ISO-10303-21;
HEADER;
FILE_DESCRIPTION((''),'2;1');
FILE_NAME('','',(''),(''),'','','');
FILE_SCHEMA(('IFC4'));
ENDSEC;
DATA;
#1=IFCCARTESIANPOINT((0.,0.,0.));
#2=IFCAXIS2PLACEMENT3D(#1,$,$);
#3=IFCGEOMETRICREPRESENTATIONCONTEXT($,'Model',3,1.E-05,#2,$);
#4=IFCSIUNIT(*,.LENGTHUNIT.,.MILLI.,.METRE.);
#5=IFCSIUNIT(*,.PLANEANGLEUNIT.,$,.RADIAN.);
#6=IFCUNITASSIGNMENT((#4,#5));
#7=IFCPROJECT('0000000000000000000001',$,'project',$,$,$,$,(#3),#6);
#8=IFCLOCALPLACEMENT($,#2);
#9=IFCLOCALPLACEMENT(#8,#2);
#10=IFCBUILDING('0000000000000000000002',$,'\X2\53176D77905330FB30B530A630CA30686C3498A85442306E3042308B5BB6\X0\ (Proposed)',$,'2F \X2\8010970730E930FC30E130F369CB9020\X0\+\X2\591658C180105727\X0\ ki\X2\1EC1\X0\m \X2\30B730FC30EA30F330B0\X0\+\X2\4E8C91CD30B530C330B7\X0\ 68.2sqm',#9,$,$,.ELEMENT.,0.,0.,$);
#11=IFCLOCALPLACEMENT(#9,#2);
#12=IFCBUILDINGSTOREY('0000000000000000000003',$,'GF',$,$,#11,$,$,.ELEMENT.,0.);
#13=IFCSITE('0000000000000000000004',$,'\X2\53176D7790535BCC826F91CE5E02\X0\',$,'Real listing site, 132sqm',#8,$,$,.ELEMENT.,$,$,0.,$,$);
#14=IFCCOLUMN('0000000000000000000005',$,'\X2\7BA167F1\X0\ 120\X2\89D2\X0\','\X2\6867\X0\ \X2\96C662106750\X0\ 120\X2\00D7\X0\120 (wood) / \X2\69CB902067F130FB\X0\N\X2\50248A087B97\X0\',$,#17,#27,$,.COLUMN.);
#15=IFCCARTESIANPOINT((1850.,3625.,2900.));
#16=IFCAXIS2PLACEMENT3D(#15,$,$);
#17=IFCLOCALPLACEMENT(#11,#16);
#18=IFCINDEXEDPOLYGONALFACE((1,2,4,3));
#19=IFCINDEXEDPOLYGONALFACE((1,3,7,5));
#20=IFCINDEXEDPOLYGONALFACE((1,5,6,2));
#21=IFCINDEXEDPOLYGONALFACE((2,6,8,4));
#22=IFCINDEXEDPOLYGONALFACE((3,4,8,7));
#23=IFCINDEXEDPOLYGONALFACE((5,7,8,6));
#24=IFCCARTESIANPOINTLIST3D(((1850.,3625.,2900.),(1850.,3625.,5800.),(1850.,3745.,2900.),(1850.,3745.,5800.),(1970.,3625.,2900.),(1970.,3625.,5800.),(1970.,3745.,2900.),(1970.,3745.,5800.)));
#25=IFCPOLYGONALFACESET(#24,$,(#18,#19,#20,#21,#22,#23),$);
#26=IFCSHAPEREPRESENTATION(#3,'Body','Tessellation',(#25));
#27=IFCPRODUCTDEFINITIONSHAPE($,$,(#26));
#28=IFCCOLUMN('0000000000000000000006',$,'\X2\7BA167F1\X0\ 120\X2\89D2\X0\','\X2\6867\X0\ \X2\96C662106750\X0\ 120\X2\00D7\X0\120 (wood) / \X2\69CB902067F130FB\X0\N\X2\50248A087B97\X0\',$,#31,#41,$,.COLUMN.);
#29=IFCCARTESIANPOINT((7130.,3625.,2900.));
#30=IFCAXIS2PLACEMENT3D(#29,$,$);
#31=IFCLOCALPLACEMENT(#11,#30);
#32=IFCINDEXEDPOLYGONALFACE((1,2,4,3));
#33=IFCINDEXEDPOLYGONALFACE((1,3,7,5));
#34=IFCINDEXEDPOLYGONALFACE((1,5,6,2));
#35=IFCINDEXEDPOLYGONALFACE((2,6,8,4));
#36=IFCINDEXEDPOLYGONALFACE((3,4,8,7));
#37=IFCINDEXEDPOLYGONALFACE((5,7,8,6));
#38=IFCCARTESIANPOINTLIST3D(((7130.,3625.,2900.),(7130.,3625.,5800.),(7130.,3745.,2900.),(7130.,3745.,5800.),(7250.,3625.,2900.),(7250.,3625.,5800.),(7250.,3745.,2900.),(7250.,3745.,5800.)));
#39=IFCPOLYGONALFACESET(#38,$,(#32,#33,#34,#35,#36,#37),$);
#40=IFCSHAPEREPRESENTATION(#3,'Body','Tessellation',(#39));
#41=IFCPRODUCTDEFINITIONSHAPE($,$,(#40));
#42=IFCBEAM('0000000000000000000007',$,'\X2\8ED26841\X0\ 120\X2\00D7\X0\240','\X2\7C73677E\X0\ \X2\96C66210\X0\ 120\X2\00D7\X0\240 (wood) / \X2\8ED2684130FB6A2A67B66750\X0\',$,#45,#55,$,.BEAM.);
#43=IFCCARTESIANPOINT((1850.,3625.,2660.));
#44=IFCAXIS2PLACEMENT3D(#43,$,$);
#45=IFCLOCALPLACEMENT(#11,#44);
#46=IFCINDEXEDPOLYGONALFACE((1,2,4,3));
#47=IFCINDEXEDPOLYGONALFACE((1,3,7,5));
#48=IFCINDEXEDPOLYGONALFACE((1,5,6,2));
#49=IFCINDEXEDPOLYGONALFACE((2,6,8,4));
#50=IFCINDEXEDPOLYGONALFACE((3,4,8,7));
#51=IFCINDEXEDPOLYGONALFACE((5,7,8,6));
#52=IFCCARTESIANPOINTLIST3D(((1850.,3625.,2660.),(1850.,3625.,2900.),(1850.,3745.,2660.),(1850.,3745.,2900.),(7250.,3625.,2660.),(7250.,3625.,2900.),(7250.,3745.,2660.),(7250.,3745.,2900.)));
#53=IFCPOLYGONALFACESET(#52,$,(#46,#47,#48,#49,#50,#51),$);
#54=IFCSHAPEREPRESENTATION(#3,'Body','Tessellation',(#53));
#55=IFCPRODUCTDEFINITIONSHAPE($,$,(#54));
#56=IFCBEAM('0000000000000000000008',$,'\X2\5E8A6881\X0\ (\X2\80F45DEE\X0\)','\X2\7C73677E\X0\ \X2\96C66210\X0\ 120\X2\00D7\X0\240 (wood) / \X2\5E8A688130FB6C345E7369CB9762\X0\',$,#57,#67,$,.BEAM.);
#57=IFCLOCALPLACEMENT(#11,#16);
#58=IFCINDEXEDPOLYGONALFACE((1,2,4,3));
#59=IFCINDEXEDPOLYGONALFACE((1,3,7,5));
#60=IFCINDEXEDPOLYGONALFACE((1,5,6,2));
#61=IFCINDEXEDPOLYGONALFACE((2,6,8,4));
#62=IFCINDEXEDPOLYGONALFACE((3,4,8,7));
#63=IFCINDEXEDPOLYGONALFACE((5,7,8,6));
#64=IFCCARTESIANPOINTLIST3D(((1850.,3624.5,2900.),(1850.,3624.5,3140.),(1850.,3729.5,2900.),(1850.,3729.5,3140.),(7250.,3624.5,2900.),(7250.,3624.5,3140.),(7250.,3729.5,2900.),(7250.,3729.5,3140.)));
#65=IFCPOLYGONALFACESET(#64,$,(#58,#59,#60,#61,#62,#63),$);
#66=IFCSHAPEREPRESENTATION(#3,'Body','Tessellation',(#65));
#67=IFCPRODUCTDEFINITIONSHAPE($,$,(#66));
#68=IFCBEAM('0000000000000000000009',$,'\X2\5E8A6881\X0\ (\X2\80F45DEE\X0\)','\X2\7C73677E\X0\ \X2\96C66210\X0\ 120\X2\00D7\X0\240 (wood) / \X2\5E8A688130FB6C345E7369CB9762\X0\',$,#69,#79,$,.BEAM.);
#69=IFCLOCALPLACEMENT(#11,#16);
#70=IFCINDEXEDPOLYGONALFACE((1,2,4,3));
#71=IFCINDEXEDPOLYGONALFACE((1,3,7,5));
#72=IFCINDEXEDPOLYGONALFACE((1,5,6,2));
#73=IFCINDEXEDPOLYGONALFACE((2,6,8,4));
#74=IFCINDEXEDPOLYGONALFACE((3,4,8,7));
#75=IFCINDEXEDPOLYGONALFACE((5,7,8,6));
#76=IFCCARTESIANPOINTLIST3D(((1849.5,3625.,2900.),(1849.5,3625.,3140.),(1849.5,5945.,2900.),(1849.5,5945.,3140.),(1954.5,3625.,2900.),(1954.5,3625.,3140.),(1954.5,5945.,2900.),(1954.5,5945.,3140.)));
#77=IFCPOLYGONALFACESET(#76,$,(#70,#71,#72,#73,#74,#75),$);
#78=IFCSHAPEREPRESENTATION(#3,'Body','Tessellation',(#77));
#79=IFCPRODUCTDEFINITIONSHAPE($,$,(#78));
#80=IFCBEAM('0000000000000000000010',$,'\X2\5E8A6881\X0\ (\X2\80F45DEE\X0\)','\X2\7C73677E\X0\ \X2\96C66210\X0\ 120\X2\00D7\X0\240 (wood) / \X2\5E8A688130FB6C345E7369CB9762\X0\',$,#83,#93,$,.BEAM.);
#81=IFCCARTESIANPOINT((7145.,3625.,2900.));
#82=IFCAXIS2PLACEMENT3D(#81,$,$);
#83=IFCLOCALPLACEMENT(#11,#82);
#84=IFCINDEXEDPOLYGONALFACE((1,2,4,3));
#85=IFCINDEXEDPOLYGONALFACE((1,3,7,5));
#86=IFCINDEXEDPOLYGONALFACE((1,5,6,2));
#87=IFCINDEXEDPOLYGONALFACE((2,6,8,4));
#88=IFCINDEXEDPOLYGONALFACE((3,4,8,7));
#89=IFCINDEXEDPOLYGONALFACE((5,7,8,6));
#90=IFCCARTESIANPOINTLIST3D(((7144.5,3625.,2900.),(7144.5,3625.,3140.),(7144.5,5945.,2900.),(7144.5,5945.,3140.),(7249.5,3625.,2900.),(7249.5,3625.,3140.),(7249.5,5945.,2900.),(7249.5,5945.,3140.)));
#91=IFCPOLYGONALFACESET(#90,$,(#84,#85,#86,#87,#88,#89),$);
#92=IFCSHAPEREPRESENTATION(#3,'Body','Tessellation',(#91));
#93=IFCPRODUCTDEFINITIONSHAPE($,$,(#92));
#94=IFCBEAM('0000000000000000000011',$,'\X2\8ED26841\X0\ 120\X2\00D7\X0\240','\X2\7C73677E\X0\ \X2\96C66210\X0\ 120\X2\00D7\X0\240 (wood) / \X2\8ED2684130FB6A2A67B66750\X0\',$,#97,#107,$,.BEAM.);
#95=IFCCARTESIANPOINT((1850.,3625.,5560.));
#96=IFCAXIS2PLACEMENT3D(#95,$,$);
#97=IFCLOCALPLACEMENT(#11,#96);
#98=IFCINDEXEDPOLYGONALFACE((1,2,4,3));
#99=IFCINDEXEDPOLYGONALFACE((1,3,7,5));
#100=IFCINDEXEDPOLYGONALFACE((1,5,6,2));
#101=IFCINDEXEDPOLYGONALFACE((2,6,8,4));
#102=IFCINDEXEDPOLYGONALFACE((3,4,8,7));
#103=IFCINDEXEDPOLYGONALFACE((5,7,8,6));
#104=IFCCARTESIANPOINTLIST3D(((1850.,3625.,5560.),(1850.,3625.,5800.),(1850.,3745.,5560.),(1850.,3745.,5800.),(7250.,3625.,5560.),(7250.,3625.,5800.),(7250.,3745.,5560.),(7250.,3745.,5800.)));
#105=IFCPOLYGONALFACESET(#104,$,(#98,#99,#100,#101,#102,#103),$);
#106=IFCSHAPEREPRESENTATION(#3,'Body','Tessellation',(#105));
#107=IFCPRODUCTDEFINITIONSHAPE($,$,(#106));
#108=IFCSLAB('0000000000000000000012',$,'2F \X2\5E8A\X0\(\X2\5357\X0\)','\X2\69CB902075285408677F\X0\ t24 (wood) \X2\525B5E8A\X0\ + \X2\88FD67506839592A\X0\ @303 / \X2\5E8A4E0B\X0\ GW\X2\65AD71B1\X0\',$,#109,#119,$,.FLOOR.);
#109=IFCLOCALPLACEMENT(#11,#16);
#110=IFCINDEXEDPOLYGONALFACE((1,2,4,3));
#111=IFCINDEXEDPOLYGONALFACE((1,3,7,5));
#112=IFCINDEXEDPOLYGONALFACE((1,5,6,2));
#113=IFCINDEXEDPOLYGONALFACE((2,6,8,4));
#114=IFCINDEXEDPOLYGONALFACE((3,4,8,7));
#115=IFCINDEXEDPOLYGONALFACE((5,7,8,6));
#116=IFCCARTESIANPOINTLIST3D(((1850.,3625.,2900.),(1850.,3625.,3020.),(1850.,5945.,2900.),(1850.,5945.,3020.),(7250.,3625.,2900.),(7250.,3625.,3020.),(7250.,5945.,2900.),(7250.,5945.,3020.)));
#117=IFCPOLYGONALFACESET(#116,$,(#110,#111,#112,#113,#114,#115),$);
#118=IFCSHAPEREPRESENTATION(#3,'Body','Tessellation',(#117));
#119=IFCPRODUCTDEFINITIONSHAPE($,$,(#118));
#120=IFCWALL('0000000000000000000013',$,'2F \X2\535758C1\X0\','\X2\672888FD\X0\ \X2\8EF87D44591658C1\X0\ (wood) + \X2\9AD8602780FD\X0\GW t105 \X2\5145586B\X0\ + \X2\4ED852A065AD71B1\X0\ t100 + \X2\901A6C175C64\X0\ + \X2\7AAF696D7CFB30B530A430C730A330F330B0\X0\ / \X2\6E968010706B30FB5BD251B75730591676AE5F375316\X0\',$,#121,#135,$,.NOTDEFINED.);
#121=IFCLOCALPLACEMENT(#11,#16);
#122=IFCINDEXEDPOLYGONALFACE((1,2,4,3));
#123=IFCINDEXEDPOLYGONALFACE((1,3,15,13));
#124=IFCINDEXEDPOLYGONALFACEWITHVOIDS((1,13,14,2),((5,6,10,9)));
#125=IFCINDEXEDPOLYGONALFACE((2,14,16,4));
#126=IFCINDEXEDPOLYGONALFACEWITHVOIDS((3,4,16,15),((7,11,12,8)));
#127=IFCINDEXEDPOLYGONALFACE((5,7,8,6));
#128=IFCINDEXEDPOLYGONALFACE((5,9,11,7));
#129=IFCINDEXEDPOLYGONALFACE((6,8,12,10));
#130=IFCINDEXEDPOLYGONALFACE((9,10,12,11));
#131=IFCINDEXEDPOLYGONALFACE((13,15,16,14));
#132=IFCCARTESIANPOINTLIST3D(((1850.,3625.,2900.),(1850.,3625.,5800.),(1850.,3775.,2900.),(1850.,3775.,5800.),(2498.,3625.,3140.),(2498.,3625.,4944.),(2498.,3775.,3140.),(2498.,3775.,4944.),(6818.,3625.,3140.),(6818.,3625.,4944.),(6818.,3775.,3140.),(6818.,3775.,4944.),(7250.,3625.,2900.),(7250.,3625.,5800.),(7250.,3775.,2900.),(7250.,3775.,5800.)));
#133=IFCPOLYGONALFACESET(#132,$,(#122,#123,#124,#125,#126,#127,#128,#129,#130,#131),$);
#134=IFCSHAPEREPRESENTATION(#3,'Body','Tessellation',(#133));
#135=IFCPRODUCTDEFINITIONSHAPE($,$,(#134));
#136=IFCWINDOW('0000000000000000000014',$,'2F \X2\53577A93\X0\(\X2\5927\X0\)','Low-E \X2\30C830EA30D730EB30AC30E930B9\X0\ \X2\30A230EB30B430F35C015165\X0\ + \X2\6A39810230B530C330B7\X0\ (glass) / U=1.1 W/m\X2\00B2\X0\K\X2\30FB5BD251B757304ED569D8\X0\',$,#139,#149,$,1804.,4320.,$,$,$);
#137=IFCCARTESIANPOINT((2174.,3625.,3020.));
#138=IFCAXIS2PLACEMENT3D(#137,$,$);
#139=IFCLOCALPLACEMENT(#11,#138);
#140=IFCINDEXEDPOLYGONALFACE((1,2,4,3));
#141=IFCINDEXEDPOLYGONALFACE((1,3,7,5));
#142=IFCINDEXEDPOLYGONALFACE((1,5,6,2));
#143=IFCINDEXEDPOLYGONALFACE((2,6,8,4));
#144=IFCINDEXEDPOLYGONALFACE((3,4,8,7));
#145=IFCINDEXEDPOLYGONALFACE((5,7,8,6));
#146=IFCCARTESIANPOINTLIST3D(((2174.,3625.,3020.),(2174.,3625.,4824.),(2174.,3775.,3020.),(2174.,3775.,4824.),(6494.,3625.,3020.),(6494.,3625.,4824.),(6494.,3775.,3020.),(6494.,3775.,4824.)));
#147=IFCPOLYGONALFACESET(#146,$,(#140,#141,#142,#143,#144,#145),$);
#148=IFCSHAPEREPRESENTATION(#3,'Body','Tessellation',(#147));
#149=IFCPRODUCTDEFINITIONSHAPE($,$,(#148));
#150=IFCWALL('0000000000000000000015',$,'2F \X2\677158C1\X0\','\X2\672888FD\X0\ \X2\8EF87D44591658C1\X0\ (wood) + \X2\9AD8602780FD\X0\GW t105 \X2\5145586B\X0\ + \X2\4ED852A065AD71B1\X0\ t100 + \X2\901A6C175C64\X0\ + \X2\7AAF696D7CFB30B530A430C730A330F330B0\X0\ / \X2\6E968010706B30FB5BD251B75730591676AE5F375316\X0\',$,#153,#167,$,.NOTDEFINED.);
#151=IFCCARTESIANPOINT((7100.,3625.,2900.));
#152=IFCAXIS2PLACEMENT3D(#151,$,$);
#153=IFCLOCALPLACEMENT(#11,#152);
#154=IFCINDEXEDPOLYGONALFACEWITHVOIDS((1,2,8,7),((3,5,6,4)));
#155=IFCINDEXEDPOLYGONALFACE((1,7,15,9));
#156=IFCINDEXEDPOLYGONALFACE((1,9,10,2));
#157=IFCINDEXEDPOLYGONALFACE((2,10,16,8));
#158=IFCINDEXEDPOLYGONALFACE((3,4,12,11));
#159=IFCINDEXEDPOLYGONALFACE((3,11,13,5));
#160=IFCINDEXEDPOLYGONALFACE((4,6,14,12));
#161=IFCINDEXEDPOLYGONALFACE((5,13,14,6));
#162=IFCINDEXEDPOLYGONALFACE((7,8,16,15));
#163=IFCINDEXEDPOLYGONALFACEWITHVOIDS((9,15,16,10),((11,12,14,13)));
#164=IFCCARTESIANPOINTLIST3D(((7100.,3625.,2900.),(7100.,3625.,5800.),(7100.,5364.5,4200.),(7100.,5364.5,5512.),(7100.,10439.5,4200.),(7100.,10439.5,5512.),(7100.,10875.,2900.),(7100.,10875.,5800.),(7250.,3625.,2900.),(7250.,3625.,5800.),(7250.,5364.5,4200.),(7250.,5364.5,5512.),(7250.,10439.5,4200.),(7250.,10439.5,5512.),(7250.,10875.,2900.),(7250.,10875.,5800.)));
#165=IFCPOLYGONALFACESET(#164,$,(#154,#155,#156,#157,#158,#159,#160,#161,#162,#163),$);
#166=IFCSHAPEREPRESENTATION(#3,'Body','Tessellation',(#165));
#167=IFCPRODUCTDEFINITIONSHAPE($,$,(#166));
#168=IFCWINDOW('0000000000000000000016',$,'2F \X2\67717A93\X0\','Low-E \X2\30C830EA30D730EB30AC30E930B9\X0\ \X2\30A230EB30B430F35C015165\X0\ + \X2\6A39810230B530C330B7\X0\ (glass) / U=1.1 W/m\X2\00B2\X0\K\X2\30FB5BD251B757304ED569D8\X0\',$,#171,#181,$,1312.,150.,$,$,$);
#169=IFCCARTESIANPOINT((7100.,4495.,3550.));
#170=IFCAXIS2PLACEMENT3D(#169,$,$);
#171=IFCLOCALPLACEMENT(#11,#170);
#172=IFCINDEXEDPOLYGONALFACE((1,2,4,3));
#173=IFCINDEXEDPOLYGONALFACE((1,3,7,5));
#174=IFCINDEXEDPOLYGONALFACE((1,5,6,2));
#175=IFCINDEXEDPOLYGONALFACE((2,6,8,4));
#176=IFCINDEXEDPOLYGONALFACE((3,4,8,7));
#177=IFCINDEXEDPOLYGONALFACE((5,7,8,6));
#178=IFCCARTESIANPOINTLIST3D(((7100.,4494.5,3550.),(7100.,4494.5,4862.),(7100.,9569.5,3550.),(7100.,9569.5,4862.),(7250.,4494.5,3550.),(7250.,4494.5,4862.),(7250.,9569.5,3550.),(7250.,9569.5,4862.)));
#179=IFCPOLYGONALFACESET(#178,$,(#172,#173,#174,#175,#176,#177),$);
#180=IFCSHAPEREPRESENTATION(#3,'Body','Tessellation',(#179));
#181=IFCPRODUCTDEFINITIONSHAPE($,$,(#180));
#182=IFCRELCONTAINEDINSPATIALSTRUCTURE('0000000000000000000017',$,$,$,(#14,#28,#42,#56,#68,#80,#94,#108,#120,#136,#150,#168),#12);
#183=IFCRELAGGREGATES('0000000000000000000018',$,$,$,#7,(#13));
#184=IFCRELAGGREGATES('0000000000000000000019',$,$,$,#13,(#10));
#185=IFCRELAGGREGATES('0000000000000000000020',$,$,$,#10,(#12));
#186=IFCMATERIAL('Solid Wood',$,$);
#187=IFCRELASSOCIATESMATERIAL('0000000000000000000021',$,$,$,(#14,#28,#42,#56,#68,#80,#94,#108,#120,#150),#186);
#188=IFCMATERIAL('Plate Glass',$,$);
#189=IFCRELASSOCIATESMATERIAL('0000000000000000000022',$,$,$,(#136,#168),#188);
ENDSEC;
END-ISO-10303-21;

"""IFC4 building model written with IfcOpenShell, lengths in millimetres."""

from ifc_helpers import new_model, si_unit, frame, frame_2d, origin, place, context, project, spatial, rectangle, extrude, material, element, fill, save


model = new_model("IFC4")

# Units and contexts
model_context = context("Model", 3, precision=1e-05, world=origin())
ifc_project = project(units=[si_unit("LENGTHUNIT", "METRE", prefix="MILLI"), si_unit("PLANEANGLEUNIT", "RADIAN")], contexts=[model_context])

# Site, building, storey
site_placement = place(None, origin())
site = spatial("IfcSite", under=ifc_project, at=site_placement, Name="北海道富良野市", ObjectType="Real listing site, 132sqm", CompositionType="ELEMENT", RefElevation=0.0)
building_placement = place(site_placement, origin())
building = spatial("IfcBuilding", under=site, at=building_placement, Name="北海道・サウナと水風呂のある家 (Proposed)", ObjectType="2F 耐震ラーメン構造+外壁耐圧 kiềm シーリング+二重サッシ 68.2sqm", CompositionType="ELEMENT", ElevationOfRefHeight=0.0, ElevationOfTerrain=0.0)
storey_placement = place(building_placement, origin())
storey = spatial("IfcBuildingStorey", under=building, at=storey_placement, Name="GF", CompositionType="ELEMENT", Elevation=0.0)

# Columns
ifc_material_1 = material(Name="Solid Wood")
column_1_placement = place(storey_placement, frame((1850.0, 3625.0, 2900.0)))
element("IfcColumn", 1, at=column_1_placement, inside=storey, material=ifc_material_1, Name="管柱 120角", Description="桧 集成材 120×120 (wood) / 構造柱・N値計算", PredefinedType="COLUMN", context=model_context, shape_type="SweptSolid", body=[
    extrude(rectangle(XDim=120.0, YDim=120.0, at=frame_2d((60.0, 60.0))), frame((1850.0, 3625.0, 2900.0)), (0.0, 0.0, 1.0), 2900.0),
])
column_2_placement = place(storey_placement, frame((7130.0, 3625.0, 2900.0)))
element("IfcColumn", 2, at=column_2_placement, inside=storey, material=ifc_material_1, Name="管柱 120角", Description="桧 集成材 120×120 (wood) / 構造柱・N値計算", PredefinedType="COLUMN", context=model_context, shape_type="SweptSolid", body=[
    extrude(rectangle(XDim=120.0, YDim=120.0, at=frame_2d((60.0, 60.0))), frame((7130.0, 3625.0, 2900.0)), (0.0, 0.0, 1.0), 2900.0),
])

# Beams
beam_1_placement = place(storey_placement, frame((1850.0, 3625.0, 2660.0)))
element("IfcBeam", 3, at=beam_1_placement, inside=storey, material=ifc_material_1, Name="軒桁 120×240", Description="米松 集成 120×240 (wood) / 軒桁・横架材", PredefinedType="BEAM", context=model_context, shape_type="SweptSolid", body=[
    extrude(rectangle(XDim=5400.0, YDim=120.0, at=frame_2d((2700.0, 60.0))), frame((1850.0, 3625.0, 2660.0)), (0.0, 0.0, 1.0), 240.0),
])
beam_2_placement = place(storey_placement, frame((1850.0, 3625.0, 2900.0)))
element("IfcBeam", 4, at=beam_2_placement, inside=storey, material=ifc_material_1, Name="床梁 (胴差)", Description="米松 集成 120×240 (wood) / 床梁・水平構面", PredefinedType="BEAM", context=model_context, shape_type="SweptSolid", body=[
    extrude(rectangle(XDim=5400.0, YDim=105.0, at=frame_2d((2700.0, 52.0))), frame((1850.0, 3625.0, 2900.0)), (0.0, 0.0, 1.0), 240.0),
])
beam_3_placement = place(storey_placement, frame((1850.0, 3625.0, 2900.0)))
element("IfcBeam", 5, at=beam_3_placement, inside=storey, material=ifc_material_1, Name="床梁 (胴差)", Description="米松 集成 120×240 (wood) / 床梁・水平構面", PredefinedType="BEAM", context=model_context, shape_type="SweptSolid", body=[
    extrude(rectangle(XDim=105.0, YDim=2320.0, at=frame_2d((52.0, 1160.0))), frame((1850.0, 3625.0, 2900.0)), (0.0, 0.0, 1.0), 240.0),
])
beam_4_placement = place(storey_placement, frame((7145.0, 3625.0, 2900.0)))
element("IfcBeam", 6, at=beam_4_placement, inside=storey, material=ifc_material_1, Name="床梁 (胴差)", Description="米松 集成 120×240 (wood) / 床梁・水平構面", PredefinedType="BEAM", context=model_context, shape_type="SweptSolid", body=[
    extrude(rectangle(XDim=105.0, YDim=2320.0, at=frame_2d((52.0, 1160.0))), frame((7145.0, 3625.0, 2900.0)), (0.0, 0.0, 1.0), 240.0),
])
beam_5_placement = place(storey_placement, frame((1850.0, 3625.0, 5560.0)))
element("IfcBeam", 7, at=beam_5_placement, inside=storey, material=ifc_material_1, Name="軒桁 120×240", Description="米松 集成 120×240 (wood) / 軒桁・横架材", PredefinedType="BEAM", context=model_context, shape_type="SweptSolid", body=[
    extrude(rectangle(XDim=5400.0, YDim=120.0, at=frame_2d((2700.0, 60.0))), frame((1850.0, 3625.0, 5560.0)), (0.0, 0.0, 1.0), 240.0),
])

# Slab
slab_placement = place(storey_placement, frame((1850.0, 3625.0, 2900.0)))
element("IfcSlab", 8, at=slab_placement, inside=storey, material=ifc_material_1, Name="2F 床(南)", Description="構造用合板 t24 (wood) 剛床 + 製材根太 @303 / 床下 GW断熱", PredefinedType="FLOOR", context=model_context, shape_type="SweptSolid", body=[
    extrude(rectangle(XDim=5400.0, YDim=2320.0, at=frame_2d((2700.0, 1160.0))), frame((1850.0, 3625.0, 2900.0)), (0.0, 0.0, 1.0), 120.0),
])

# Walls, openings, windows
wall_1_placement = place(storey_placement, frame((1850.0, 3625.0, 2900.0)))
wall_1 = element("IfcWall", 9, at=wall_1_placement, inside=storey, material=ifc_material_1, Name="2F 南壁", Description="木製 軸組外壁 (wood) + 高性能GW t105 充填 + 付加断熱 t100 + 通気層 + 窯業系サイディング / 準耐火・寒冷地外皮強化", PredefinedType="NOTDEFINED", context=model_context, shape_type="SweptSolid", body=[
    extrude(rectangle(XDim=5400.0, YDim=150.0, at=frame_2d((2700.0, 75.0))), frame((1850.0, 3625.0, 2900.0)), (0.0, 0.0, 1.0), 2900.0),
])
opening_1_placement = place(storey_placement, frame((2174.0, 3625.0, 3020.0)))
opening_1 = element("IfcOpeningElement", 10, at=opening_1_placement, cuts=wall_1, PredefinedType="NOTDEFINED", context=model_context, shape_type="SweptSolid", body=[
    extrude(rectangle(XDim=4320.0, YDim=150.0, at=frame_2d((2160.0, 75.0))), frame((2174.0, 3625.0, 3020.0)), (0.0, 0.0, 1.0), 1804.0),
])
ifc_material_2 = material(Name="Plate Glass")
window_1_placement = place(storey_placement, frame((2174.0, 3625.0, 3020.0)))
window_1 = element("IfcWindow", 11, at=window_1_placement, inside=storey, material=ifc_material_2, Name="2F 南窓(大)", Description="Low-E トリプルガラス アルゴン封入 + 樹脂サッシ (glass) / U=1.1 W/m²K・寒冷地仕様", OverallHeight=1804.0, OverallWidth=4320.0, context=model_context, shape_type="SweptSolid", body=[
    extrude(rectangle(XDim=4320.0, YDim=150.0, at=frame_2d((2160.0, 75.0))), frame((2174.0, 3625.0, 3020.0)), (0.0, 0.0, 1.0), 1804.0),
])
fill(opening_1, window_1)
wall_2_placement = place(storey_placement, frame((7100.0, 3625.0, 2900.0)))
wall_2 = element("IfcWall", 12, at=wall_2_placement, inside=storey, material=ifc_material_1, Name="2F 東壁", Description="木製 軸組外壁 (wood) + 高性能GW t105 充填 + 付加断熱 t100 + 通気層 + 窯業系サイディング / 準耐火・寒冷地外皮強化", PredefinedType="NOTDEFINED", context=model_context, shape_type="SweptSolid", body=[
    extrude(rectangle(XDim=150.0, YDim=7250.0, at=frame_2d((75.0, 3625.0))), frame((7100.0, 3625.0, 2900.0)), (0.0, 0.0, 1.0), 2900.0),
])
opening_2_placement = place(storey_placement, frame((7100.0, 4495.0, 3550.0)))
opening_2 = element("IfcOpeningElement", 13, at=opening_2_placement, cuts=wall_2, PredefinedType="NOTDEFINED", context=model_context, shape_type="SweptSolid", body=[
    extrude(rectangle(XDim=150.0, YDim=5075.0, at=frame_2d((75.0, 2537.0))), frame((7100.0, 4495.0, 3550.0)), (0.0, 0.0, 1.0), 1312.0),
])
window_2_placement = place(storey_placement, frame((7100.0, 4495.0, 3550.0)))
window_2 = element("IfcWindow", 14, at=window_2_placement, inside=storey, material=ifc_material_2, Name="2F 東窓", Description="Low-E トリプルガラス アルゴン封入 + 樹脂サッシ (glass) / U=1.1 W/m²K・寒冷地仕様", OverallHeight=1312.0, OverallWidth=150.0, context=model_context, shape_type="SweptSolid", body=[
    extrude(rectangle(XDim=150.0, YDim=5075.0, at=frame_2d((75.0, 2537.0))), frame((7100.0, 4495.0, 3550.0)), (0.0, 0.0, 1.0), 1312.0),
])
fill(opening_2, window_2)

save(model, "model.ifc")
